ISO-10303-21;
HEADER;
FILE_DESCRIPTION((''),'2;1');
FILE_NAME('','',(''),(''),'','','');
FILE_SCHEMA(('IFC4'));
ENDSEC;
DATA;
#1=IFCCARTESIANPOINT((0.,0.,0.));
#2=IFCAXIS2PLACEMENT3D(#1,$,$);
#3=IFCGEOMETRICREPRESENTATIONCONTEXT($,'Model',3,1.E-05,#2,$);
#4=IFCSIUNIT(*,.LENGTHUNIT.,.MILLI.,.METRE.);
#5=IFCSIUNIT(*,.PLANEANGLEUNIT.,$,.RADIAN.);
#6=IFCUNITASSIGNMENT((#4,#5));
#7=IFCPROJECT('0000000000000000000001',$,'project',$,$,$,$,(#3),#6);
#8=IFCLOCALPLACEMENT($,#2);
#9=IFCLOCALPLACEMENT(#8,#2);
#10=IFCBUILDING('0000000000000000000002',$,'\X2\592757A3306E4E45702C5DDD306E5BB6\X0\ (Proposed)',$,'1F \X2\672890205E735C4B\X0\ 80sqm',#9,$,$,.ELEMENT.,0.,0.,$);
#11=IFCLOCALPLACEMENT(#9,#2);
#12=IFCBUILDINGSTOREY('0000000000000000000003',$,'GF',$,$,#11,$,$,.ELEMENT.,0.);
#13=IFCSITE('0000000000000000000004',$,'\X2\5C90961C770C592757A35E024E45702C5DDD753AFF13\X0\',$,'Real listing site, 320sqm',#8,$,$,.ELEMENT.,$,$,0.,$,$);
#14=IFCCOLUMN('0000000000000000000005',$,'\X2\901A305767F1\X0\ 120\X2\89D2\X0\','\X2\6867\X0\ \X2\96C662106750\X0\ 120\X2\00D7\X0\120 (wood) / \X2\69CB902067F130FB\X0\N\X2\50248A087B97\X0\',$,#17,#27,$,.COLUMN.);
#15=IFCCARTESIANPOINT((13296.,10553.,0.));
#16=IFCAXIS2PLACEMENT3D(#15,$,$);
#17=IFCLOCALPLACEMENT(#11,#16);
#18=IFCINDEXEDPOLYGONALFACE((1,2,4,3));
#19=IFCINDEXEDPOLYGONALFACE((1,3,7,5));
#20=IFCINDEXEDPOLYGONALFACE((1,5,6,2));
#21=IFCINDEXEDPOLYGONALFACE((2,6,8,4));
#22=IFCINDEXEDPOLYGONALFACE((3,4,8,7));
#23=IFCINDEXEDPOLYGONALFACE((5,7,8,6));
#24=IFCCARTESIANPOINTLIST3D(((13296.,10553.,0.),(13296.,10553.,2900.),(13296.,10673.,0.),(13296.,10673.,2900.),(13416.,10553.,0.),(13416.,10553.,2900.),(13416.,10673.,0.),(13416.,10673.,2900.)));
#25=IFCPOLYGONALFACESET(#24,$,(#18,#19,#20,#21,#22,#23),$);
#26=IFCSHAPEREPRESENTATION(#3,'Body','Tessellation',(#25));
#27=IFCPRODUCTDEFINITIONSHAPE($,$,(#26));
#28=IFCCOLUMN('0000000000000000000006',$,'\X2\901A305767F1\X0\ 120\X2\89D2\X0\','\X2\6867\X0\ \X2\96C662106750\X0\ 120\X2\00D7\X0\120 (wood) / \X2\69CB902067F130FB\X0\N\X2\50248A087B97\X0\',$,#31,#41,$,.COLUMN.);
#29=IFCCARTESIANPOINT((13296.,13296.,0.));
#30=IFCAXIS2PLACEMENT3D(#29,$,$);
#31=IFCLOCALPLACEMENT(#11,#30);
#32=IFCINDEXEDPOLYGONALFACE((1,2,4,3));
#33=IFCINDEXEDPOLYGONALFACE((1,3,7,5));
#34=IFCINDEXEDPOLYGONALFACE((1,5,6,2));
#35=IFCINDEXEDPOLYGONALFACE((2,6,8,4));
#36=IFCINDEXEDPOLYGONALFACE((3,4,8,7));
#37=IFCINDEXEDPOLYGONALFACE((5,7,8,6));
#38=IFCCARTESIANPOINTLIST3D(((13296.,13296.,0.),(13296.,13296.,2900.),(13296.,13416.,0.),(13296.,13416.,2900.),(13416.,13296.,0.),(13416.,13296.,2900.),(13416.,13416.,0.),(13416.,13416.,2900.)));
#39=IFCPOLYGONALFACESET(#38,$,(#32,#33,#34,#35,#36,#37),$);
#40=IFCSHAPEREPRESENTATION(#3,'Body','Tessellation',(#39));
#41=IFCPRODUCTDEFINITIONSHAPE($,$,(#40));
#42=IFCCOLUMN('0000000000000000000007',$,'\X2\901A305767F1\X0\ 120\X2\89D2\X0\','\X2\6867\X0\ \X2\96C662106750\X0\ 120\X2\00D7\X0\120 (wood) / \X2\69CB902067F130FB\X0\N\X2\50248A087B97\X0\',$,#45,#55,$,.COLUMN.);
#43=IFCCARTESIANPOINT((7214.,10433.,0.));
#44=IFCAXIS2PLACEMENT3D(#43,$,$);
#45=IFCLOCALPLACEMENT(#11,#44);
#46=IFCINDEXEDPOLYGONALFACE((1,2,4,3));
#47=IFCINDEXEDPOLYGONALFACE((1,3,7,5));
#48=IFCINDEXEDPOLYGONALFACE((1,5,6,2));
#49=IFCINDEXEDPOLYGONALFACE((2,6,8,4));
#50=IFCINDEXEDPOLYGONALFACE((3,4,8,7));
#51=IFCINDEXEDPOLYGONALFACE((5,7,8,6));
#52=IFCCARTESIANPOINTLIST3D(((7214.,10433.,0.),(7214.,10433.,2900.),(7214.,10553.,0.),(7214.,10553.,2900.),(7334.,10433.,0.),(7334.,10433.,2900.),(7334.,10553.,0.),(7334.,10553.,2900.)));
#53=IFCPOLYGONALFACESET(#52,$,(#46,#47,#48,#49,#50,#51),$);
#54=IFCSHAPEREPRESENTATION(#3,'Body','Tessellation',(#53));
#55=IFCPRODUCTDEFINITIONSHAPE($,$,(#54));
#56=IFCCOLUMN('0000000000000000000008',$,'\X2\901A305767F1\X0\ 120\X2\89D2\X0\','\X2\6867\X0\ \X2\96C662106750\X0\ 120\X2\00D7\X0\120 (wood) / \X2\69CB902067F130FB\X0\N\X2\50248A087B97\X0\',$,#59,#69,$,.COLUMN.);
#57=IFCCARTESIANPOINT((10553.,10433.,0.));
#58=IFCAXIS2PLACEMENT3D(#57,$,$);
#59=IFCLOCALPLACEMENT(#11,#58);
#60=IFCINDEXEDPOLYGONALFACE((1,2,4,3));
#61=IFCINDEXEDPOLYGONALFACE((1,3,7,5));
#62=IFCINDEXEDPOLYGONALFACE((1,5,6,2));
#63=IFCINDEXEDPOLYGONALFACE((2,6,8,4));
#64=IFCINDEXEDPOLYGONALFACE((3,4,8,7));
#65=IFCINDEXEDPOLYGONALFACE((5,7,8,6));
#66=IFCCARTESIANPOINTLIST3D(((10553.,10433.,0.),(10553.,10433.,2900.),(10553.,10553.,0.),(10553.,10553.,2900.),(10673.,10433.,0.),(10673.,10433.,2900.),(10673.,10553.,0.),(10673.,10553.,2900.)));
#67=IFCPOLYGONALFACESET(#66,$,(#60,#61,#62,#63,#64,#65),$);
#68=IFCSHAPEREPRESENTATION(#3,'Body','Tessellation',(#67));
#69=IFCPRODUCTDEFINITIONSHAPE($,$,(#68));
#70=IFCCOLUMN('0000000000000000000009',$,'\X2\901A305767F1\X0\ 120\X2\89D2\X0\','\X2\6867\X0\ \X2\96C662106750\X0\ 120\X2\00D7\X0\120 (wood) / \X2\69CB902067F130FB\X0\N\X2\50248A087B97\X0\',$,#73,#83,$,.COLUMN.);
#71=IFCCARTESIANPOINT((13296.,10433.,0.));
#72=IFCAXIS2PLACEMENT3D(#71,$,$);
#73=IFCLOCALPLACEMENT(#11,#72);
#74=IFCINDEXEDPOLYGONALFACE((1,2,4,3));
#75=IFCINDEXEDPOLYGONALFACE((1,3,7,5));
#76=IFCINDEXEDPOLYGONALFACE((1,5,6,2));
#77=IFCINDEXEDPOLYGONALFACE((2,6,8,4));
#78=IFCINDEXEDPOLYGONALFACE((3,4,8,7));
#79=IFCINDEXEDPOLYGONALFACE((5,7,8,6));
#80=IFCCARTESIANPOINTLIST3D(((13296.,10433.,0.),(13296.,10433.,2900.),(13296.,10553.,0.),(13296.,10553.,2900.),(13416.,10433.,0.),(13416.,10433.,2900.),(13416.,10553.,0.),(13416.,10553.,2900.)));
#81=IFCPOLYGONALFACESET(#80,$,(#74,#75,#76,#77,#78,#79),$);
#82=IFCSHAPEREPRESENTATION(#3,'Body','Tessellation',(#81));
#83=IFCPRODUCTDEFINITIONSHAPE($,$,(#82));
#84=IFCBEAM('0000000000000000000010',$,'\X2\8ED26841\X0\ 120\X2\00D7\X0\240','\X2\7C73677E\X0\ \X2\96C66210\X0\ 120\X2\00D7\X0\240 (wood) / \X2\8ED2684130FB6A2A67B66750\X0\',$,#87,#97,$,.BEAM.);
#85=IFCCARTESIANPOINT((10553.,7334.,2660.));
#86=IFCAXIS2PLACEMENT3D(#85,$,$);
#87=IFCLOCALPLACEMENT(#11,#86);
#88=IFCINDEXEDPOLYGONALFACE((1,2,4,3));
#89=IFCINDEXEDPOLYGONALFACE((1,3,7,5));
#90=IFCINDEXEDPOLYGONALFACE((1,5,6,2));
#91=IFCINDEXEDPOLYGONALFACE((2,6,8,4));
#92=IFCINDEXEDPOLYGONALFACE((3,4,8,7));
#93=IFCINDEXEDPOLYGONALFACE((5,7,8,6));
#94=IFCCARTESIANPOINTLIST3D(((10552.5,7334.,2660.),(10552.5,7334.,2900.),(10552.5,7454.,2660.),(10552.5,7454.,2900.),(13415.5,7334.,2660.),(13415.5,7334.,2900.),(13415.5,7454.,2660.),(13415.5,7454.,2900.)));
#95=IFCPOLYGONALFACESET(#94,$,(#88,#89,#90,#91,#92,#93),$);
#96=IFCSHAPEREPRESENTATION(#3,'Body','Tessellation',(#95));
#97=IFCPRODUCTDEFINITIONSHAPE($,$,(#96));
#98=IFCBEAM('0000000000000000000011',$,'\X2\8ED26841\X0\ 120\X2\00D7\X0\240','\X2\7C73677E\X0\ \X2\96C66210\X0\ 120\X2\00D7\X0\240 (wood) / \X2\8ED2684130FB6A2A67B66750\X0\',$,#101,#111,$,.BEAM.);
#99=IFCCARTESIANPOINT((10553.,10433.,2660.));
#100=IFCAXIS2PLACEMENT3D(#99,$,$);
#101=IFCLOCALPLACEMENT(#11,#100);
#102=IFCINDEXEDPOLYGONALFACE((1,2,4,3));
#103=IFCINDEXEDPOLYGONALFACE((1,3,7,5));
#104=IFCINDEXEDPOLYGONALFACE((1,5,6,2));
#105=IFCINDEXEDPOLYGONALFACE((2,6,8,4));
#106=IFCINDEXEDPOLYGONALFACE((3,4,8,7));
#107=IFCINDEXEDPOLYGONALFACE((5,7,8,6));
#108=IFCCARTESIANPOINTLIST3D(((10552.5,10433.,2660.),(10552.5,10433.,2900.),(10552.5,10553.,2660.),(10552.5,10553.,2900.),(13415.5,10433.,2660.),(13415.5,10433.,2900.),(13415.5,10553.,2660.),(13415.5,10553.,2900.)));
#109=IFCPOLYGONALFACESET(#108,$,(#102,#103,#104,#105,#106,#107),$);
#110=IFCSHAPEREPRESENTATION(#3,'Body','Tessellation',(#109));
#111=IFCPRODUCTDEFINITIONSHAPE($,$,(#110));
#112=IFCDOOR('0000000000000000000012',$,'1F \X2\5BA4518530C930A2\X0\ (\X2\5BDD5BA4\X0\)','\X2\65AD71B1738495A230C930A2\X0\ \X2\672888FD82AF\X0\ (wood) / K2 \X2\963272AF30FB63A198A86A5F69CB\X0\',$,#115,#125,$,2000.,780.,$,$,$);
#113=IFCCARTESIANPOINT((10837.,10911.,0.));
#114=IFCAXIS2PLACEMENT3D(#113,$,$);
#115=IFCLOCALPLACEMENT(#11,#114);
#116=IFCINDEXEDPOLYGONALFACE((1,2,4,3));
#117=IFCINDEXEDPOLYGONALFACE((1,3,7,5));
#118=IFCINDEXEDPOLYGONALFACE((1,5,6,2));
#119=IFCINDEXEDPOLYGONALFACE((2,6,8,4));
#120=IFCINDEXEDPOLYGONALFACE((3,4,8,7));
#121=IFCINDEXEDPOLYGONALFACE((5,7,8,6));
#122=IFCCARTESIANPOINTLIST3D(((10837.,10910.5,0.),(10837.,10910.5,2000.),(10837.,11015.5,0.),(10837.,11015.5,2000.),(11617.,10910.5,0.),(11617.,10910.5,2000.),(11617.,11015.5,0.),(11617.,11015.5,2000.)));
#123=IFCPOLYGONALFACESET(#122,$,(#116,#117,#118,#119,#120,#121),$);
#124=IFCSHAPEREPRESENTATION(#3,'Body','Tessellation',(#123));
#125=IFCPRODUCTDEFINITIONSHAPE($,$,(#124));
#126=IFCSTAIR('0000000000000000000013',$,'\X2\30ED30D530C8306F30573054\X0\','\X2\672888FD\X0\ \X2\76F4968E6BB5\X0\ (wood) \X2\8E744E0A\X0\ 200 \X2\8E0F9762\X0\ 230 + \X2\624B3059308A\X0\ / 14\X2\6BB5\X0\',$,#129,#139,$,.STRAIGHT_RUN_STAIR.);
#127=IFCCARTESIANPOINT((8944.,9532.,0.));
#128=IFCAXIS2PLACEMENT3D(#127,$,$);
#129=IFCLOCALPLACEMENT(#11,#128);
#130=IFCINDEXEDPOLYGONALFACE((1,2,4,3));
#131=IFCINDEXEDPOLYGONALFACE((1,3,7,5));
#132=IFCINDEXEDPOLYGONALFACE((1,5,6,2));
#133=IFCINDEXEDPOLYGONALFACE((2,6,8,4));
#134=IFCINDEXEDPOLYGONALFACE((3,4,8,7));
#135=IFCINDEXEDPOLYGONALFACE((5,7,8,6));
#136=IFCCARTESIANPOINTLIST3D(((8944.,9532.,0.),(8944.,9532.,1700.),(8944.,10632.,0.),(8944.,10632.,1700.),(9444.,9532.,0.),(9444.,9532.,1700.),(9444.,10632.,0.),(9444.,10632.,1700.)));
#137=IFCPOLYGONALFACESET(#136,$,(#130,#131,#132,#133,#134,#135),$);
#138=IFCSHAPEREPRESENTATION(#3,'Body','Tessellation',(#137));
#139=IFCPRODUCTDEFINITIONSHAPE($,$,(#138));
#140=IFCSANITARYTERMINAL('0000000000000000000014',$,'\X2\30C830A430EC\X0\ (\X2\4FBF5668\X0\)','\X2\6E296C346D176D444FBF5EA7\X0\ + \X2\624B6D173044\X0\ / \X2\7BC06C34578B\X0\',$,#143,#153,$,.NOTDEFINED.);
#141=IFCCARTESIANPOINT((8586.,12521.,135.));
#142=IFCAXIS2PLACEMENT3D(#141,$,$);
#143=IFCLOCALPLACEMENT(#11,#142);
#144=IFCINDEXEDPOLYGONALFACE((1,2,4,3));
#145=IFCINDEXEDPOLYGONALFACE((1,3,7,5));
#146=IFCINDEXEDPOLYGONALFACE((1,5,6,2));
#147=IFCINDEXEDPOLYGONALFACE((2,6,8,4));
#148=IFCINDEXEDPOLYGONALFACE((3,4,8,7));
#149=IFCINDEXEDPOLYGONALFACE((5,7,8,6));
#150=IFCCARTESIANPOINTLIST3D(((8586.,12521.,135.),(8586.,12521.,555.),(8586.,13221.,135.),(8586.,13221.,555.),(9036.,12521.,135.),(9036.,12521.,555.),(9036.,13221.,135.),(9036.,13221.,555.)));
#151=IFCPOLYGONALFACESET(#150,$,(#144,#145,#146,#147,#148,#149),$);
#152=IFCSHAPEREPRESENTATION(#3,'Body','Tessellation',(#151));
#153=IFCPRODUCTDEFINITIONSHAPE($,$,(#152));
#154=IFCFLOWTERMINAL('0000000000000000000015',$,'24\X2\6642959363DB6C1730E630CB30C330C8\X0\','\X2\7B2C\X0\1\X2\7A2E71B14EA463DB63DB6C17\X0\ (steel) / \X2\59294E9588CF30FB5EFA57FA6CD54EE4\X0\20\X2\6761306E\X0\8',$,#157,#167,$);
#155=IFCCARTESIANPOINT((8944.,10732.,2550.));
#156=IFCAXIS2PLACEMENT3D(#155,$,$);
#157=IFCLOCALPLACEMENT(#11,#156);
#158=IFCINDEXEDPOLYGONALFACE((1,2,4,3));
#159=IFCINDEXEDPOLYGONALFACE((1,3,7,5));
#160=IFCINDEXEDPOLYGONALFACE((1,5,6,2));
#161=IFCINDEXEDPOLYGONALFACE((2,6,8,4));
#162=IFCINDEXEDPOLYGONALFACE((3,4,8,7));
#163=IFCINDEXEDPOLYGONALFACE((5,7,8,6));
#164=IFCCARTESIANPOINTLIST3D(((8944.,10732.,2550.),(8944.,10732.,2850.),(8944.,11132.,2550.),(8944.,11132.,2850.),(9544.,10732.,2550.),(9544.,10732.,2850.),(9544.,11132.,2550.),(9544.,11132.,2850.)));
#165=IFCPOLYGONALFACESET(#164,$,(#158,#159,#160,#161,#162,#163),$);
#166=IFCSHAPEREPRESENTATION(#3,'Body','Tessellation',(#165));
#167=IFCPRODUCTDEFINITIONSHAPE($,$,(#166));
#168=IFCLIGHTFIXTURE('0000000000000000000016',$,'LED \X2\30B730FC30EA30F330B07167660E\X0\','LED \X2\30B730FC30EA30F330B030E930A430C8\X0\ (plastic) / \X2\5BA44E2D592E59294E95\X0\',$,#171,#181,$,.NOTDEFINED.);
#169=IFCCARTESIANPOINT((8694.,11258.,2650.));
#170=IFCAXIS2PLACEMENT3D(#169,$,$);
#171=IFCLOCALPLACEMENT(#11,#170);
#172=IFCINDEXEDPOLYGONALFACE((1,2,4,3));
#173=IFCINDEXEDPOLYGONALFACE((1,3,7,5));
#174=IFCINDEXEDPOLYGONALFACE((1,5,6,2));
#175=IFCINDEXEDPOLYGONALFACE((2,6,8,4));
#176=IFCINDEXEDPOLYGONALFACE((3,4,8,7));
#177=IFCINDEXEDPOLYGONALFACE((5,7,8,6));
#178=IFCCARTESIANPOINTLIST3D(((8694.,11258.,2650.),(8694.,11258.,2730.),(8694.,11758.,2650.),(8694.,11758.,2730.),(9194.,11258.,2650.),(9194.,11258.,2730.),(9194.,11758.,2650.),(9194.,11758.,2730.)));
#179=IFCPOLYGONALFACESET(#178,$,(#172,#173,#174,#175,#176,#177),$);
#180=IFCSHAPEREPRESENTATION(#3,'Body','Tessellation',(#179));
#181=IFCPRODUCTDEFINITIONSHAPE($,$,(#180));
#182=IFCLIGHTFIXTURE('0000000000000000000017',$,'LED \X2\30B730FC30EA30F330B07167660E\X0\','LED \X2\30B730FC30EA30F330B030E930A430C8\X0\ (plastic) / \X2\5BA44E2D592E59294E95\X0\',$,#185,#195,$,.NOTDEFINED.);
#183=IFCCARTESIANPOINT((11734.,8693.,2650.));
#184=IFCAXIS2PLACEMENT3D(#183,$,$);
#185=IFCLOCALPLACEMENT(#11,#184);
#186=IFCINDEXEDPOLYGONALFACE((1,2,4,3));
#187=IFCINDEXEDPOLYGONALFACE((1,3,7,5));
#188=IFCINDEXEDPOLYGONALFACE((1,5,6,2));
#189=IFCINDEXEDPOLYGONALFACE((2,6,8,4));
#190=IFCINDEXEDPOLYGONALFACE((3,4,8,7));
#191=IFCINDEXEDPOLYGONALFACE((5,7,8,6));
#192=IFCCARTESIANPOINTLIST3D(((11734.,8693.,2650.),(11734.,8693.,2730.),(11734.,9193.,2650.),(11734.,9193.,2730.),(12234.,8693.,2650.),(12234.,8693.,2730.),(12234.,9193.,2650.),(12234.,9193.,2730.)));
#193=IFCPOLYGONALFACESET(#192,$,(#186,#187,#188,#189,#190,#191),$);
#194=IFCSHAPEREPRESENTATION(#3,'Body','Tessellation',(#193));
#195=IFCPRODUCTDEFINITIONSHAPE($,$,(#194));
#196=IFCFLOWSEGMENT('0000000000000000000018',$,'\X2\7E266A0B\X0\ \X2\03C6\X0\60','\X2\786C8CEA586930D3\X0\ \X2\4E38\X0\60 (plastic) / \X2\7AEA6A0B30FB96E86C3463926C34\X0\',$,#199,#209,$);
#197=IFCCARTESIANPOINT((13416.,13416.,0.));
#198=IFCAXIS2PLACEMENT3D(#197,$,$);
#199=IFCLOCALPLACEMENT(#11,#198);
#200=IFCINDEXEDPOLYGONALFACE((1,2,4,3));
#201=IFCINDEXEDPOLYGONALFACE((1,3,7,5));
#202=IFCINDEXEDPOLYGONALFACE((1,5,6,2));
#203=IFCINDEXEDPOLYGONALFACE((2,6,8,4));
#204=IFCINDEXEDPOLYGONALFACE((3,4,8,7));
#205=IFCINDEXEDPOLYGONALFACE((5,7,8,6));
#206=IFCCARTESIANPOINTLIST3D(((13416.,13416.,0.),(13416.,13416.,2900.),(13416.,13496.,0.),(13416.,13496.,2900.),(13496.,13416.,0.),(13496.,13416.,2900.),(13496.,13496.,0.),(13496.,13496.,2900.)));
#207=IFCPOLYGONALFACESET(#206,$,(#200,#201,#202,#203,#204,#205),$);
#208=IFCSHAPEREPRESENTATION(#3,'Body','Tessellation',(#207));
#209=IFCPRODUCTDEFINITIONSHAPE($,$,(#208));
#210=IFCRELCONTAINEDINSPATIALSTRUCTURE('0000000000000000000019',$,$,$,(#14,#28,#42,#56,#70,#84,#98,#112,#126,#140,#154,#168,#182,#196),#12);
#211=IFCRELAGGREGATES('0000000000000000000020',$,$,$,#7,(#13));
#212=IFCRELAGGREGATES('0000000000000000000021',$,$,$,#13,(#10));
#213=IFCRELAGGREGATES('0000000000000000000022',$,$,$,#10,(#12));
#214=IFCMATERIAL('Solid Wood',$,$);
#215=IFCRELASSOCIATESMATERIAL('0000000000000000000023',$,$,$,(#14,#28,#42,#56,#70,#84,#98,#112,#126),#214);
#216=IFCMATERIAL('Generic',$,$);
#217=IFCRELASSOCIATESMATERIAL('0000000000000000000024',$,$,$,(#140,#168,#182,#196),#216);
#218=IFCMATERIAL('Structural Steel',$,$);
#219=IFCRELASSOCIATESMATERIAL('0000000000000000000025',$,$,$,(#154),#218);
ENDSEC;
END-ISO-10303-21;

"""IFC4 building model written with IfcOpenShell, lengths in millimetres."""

from ifc_helpers import new_model, si_unit, frame, frame_2d, origin, place, context, project, spatial, rectangle, extrude, material, element, save


model = new_model("IFC4")

# Units and contexts
model_context = context("Model", 3, precision=1e-05, world=origin())
ifc_project = project(units=[si_unit("LENGTHUNIT", "METRE", prefix="MILLI"), si_unit("PLANEANGLEUNIT", "RADIAN")], contexts=[model_context])

# Site, building, storey
site_placement = place(None, origin())
site = spatial("IfcSite", under=ifc_project, at=site_placement, Name="岐阜県大垣市久瀬川町３", ObjectType="Real listing site, 320sqm", CompositionType="ELEMENT", RefElevation=0.0)
building_placement = place(site_placement, origin())
building = spatial("IfcBuilding", under=site, at=building_placement, Name="大垣の久瀬川の家 (Proposed)", ObjectType="1F 木造平屋 80sqm", CompositionType="ELEMENT", ElevationOfRefHeight=0.0, ElevationOfTerrain=0.0)
storey_placement = place(building_placement, origin())
storey = spatial("IfcBuildingStorey", under=building, at=storey_placement, Name="GF", CompositionType="ELEMENT", Elevation=0.0)

# Columns
ifc_material_1 = material(Name="Solid Wood")
column_1_placement = place(storey_placement, frame((13296.0, 10553.0, 0.0)))
element("IfcColumn", 1, at=column_1_placement, inside=storey, material=ifc_material_1, Name="通し柱 120角", Description="桧 集成材 120×120 (wood) / 構造柱・N値計算", PredefinedType="COLUMN", context=model_context, shape_type="SweptSolid", body=[
    extrude(rectangle(XDim=120.0, YDim=120.0, at=frame_2d((60.0, 60.0))), frame((13296.0, 10553.0, 0.0)), (0.0, 0.0, 1.0), 2900.0),
])
column_2_placement = place(storey_placement, frame((13296.0, 13296.0, 0.0)))
element("IfcColumn", 2, at=column_2_placement, inside=storey, material=ifc_material_1, Name="通し柱 120角", Description="桧 集成材 120×120 (wood) / 構造柱・N値計算", PredefinedType="COLUMN", context=model_context, shape_type="SweptSolid", body=[
    extrude(rectangle(XDim=120.0, YDim=120.0, at=frame_2d((60.0, 60.0))), frame((13296.0, 13296.0, 0.0)), (0.0, 0.0, 1.0), 2900.0),
])
column_3_placement = place(storey_placement, frame((7214.0, 10433.0, 0.0)))
element("IfcColumn", 3, at=column_3_placement, inside=storey, material=ifc_material_1, Name="通し柱 120角", Description="桧 集成材 120×120 (wood) / 構造柱・N値計算", PredefinedType="COLUMN", context=model_context, shape_type="SweptSolid", body=[
    extrude(rectangle(XDim=120.0, YDim=120.0, at=frame_2d((60.0, 60.0))), frame((7214.0, 10433.0, 0.0)), (0.0, 0.0, 1.0), 2900.0),
])
column_4_placement = place(storey_placement, frame((10553.0, 10433.0, 0.0)))
element("IfcColumn", 4, at=column_4_placement, inside=storey, material=ifc_material_1, Name="通し柱 120角", Description="桧 集成材 120×120 (wood) / 構造柱・N値計算", PredefinedType="COLUMN", context=model_context, shape_type="SweptSolid", body=[
    extrude(rectangle(XDim=120.0, YDim=120.0, at=frame_2d((60.0, 60.0))), frame((10553.0, 10433.0, 0.0)), (0.0, 0.0, 1.0), 2900.0),
])
column_5_placement = place(storey_placement, frame((13296.0, 10433.0, 0.0)))
element("IfcColumn", 5, at=column_5_placement, inside=storey, material=ifc_material_1, Name="通し柱 120角", Description="桧 集成材 120×120 (wood) / 構造柱・N値計算", PredefinedType="COLUMN", context=model_context, shape_type="SweptSolid", body=[
    extrude(rectangle(XDim=120.0, YDim=120.0, at=frame_2d((60.0, 60.0))), frame((13296.0, 10433.0, 0.0)), (0.0, 0.0, 1.0), 2900.0),
])

# Beams
beam_1_placement = place(storey_placement, frame((10553.0, 7334.0, 2660.0)))
element("IfcBeam", 6, at=beam_1_placement, inside=storey, material=ifc_material_1, Name="軒桁 120×240", Description="米松 集成 120×240 (wood) / 軒桁・横架材", PredefinedType="BEAM", context=model_context, shape_type="SweptSolid", body=[
    extrude(rectangle(XDim=2863.0, YDim=120.0, at=frame_2d((1431.0, 60.0))), frame((10553.0, 7334.0, 2660.0)), (0.0, 0.0, 1.0), 240.0),
])
beam_2_placement = place(storey_placement, frame((10553.0, 10433.0, 2660.0)))
element("IfcBeam", 7, at=beam_2_placement, inside=storey, material=ifc_material_1, Name="軒桁 120×240", Description="米松 集成 120×240 (wood) / 軒桁・横架材", PredefinedType="BEAM", context=model_context, shape_type="SweptSolid", body=[
    extrude(rectangle(XDim=2863.0, YDim=120.0, at=frame_2d((1431.0, 60.0))), frame((10553.0, 10433.0, 2660.0)), (0.0, 0.0, 1.0), 240.0),
])

# Door
door_placement = place(storey_placement, frame((10837.0, 10911.0, 0.0)))
element("IfcDoor", 8, at=door_placement, inside=storey, material=ifc_material_1, Name="1F 室内ドア (寝室)", Description="断熱玄関ドア 木製芯 (wood) / K2 防犯・採風機構", OverallHeight=2000.0, OverallWidth=780.0, context=model_context, shape_type="SweptSolid", body=[
    extrude(rectangle(XDim=780.0, YDim=105.0, at=frame_2d((390.0, 52.0))), frame((10837.0, 10911.0, 0.0)), (0.0, 0.0, 1.0), 2000.0),
])

# Stair
stair_placement = place(storey_placement, frame((8944.0, 9532.0, 0.0)))
element("IfcStair", 9, at=stair_placement, inside=storey, material=ifc_material_1, Name="ロフトはしご", Description="木製 直階段 (wood) 蹴上 200 踏面 230 + 手すり / 14段", PredefinedType="STRAIGHT_RUN_STAIR", context=model_context, shape_type="SweptSolid", body=[
    extrude(rectangle(XDim=500.0, YDim=1100.0, at=frame_2d((250.0, 550.0))), frame((8944.0, 9532.0, 0.0)), (0.0, 0.0, 1.0), 1700.0),
])

# Shared definitions
ifc_material_2 = material(Name="Generic")

# Sanitary terminal
sanitary_terminal_placement = place(storey_placement, frame((8586.0, 12521.0, 135.0)))
element("IfcSanitaryTerminal", 10, at=sanitary_terminal_placement, inside=storey, material=ifc_material_2, Name="トイレ (便器)", Description="温水洗浄便座 + 手洗い / 節水型", PredefinedType="NOTDEFINED", context=model_context, shape_type="SweptSolid", body=[
    extrude(rectangle(XDim=450.0, YDim=700.0, at=frame_2d((225.0, 350.0))), frame((8586.0, 12521.0, 135.0)), (0.0, 0.0, 1.0), 420.0),
])

# Flow terminal
ifc_material_3 = material(Name="Structural Steel")
flow_terminal_placement = place(storey_placement, frame((8944.0, 10732.0, 2550.0)))
element("IfcFlowTerminal", 11, at=flow_terminal_placement, inside=storey, material=ifc_material_3, Name="24時間換気ユニット", Description="第1種熱交換換気 (steel) / 天井裏・建基法令20条の8", context=model_context, shape_type="SweptSolid", body=[
    extrude(rectangle(XDim=600.0, YDim=400.0, at=frame_2d((300.0, 200.0))), frame((8944.0, 10732.0, 2550.0)), (0.0, 0.0, 1.0), 300.0),
])

# Light fixtures
light_fixture_1_placement = place(storey_placement, frame((8694.0, 11258.0, 2650.0)))
element("IfcLightFixture", 12, at=light_fixture_1_placement, inside=storey, material=ifc_material_2, Name="LED シーリング照明", Description="LED シーリングライト (plastic) / 室中央天井", PredefinedType="NOTDEFINED", context=model_context, shape_type="SweptSolid", body=[
    extrude(rectangle(XDim=500.0, YDim=500.0, at=frame_2d((250.0, 250.0))), frame((8694.0, 11258.0, 2650.0)), (0.0, 0.0, 1.0), 80.0),
])
light_fixture_2_placement = place(storey_placement, frame((11734.0, 8693.0, 2650.0)))
element("IfcLightFixture", 13, at=light_fixture_2_placement, inside=storey, material=ifc_material_2, Name="LED シーリング照明", Description="LED シーリングライト (plastic) / 室中央天井", PredefinedType="NOTDEFINED", context=model_context, shape_type="SweptSolid", body=[
    extrude(rectangle(XDim=500.0, YDim=500.0, at=frame_2d((250.0, 250.0))), frame((11734.0, 8693.0, 2650.0)), (0.0, 0.0, 1.0), 80.0),
])

# Flow segment
flow_segment_placement = place(storey_placement, frame((13416.0, 13416.0, 0.0)))
element("IfcFlowSegment", 14, at=flow_segment_placement, inside=storey, material=ifc_material_2, Name="縦樋 φ60", Description="硬質塩ビ 丸60 (plastic) / 竪樋・雨水排水", context=model_context, shape_type="SweptSolid", body=[
    extrude(rectangle(XDim=80.0, YDim=80.0, at=frame_2d((40.0, 40.0))), frame((13416.0, 13416.0, 0.0)), (0.0, 0.0, 1.0), 2900.0),
])

save(model, "model.ifc")
